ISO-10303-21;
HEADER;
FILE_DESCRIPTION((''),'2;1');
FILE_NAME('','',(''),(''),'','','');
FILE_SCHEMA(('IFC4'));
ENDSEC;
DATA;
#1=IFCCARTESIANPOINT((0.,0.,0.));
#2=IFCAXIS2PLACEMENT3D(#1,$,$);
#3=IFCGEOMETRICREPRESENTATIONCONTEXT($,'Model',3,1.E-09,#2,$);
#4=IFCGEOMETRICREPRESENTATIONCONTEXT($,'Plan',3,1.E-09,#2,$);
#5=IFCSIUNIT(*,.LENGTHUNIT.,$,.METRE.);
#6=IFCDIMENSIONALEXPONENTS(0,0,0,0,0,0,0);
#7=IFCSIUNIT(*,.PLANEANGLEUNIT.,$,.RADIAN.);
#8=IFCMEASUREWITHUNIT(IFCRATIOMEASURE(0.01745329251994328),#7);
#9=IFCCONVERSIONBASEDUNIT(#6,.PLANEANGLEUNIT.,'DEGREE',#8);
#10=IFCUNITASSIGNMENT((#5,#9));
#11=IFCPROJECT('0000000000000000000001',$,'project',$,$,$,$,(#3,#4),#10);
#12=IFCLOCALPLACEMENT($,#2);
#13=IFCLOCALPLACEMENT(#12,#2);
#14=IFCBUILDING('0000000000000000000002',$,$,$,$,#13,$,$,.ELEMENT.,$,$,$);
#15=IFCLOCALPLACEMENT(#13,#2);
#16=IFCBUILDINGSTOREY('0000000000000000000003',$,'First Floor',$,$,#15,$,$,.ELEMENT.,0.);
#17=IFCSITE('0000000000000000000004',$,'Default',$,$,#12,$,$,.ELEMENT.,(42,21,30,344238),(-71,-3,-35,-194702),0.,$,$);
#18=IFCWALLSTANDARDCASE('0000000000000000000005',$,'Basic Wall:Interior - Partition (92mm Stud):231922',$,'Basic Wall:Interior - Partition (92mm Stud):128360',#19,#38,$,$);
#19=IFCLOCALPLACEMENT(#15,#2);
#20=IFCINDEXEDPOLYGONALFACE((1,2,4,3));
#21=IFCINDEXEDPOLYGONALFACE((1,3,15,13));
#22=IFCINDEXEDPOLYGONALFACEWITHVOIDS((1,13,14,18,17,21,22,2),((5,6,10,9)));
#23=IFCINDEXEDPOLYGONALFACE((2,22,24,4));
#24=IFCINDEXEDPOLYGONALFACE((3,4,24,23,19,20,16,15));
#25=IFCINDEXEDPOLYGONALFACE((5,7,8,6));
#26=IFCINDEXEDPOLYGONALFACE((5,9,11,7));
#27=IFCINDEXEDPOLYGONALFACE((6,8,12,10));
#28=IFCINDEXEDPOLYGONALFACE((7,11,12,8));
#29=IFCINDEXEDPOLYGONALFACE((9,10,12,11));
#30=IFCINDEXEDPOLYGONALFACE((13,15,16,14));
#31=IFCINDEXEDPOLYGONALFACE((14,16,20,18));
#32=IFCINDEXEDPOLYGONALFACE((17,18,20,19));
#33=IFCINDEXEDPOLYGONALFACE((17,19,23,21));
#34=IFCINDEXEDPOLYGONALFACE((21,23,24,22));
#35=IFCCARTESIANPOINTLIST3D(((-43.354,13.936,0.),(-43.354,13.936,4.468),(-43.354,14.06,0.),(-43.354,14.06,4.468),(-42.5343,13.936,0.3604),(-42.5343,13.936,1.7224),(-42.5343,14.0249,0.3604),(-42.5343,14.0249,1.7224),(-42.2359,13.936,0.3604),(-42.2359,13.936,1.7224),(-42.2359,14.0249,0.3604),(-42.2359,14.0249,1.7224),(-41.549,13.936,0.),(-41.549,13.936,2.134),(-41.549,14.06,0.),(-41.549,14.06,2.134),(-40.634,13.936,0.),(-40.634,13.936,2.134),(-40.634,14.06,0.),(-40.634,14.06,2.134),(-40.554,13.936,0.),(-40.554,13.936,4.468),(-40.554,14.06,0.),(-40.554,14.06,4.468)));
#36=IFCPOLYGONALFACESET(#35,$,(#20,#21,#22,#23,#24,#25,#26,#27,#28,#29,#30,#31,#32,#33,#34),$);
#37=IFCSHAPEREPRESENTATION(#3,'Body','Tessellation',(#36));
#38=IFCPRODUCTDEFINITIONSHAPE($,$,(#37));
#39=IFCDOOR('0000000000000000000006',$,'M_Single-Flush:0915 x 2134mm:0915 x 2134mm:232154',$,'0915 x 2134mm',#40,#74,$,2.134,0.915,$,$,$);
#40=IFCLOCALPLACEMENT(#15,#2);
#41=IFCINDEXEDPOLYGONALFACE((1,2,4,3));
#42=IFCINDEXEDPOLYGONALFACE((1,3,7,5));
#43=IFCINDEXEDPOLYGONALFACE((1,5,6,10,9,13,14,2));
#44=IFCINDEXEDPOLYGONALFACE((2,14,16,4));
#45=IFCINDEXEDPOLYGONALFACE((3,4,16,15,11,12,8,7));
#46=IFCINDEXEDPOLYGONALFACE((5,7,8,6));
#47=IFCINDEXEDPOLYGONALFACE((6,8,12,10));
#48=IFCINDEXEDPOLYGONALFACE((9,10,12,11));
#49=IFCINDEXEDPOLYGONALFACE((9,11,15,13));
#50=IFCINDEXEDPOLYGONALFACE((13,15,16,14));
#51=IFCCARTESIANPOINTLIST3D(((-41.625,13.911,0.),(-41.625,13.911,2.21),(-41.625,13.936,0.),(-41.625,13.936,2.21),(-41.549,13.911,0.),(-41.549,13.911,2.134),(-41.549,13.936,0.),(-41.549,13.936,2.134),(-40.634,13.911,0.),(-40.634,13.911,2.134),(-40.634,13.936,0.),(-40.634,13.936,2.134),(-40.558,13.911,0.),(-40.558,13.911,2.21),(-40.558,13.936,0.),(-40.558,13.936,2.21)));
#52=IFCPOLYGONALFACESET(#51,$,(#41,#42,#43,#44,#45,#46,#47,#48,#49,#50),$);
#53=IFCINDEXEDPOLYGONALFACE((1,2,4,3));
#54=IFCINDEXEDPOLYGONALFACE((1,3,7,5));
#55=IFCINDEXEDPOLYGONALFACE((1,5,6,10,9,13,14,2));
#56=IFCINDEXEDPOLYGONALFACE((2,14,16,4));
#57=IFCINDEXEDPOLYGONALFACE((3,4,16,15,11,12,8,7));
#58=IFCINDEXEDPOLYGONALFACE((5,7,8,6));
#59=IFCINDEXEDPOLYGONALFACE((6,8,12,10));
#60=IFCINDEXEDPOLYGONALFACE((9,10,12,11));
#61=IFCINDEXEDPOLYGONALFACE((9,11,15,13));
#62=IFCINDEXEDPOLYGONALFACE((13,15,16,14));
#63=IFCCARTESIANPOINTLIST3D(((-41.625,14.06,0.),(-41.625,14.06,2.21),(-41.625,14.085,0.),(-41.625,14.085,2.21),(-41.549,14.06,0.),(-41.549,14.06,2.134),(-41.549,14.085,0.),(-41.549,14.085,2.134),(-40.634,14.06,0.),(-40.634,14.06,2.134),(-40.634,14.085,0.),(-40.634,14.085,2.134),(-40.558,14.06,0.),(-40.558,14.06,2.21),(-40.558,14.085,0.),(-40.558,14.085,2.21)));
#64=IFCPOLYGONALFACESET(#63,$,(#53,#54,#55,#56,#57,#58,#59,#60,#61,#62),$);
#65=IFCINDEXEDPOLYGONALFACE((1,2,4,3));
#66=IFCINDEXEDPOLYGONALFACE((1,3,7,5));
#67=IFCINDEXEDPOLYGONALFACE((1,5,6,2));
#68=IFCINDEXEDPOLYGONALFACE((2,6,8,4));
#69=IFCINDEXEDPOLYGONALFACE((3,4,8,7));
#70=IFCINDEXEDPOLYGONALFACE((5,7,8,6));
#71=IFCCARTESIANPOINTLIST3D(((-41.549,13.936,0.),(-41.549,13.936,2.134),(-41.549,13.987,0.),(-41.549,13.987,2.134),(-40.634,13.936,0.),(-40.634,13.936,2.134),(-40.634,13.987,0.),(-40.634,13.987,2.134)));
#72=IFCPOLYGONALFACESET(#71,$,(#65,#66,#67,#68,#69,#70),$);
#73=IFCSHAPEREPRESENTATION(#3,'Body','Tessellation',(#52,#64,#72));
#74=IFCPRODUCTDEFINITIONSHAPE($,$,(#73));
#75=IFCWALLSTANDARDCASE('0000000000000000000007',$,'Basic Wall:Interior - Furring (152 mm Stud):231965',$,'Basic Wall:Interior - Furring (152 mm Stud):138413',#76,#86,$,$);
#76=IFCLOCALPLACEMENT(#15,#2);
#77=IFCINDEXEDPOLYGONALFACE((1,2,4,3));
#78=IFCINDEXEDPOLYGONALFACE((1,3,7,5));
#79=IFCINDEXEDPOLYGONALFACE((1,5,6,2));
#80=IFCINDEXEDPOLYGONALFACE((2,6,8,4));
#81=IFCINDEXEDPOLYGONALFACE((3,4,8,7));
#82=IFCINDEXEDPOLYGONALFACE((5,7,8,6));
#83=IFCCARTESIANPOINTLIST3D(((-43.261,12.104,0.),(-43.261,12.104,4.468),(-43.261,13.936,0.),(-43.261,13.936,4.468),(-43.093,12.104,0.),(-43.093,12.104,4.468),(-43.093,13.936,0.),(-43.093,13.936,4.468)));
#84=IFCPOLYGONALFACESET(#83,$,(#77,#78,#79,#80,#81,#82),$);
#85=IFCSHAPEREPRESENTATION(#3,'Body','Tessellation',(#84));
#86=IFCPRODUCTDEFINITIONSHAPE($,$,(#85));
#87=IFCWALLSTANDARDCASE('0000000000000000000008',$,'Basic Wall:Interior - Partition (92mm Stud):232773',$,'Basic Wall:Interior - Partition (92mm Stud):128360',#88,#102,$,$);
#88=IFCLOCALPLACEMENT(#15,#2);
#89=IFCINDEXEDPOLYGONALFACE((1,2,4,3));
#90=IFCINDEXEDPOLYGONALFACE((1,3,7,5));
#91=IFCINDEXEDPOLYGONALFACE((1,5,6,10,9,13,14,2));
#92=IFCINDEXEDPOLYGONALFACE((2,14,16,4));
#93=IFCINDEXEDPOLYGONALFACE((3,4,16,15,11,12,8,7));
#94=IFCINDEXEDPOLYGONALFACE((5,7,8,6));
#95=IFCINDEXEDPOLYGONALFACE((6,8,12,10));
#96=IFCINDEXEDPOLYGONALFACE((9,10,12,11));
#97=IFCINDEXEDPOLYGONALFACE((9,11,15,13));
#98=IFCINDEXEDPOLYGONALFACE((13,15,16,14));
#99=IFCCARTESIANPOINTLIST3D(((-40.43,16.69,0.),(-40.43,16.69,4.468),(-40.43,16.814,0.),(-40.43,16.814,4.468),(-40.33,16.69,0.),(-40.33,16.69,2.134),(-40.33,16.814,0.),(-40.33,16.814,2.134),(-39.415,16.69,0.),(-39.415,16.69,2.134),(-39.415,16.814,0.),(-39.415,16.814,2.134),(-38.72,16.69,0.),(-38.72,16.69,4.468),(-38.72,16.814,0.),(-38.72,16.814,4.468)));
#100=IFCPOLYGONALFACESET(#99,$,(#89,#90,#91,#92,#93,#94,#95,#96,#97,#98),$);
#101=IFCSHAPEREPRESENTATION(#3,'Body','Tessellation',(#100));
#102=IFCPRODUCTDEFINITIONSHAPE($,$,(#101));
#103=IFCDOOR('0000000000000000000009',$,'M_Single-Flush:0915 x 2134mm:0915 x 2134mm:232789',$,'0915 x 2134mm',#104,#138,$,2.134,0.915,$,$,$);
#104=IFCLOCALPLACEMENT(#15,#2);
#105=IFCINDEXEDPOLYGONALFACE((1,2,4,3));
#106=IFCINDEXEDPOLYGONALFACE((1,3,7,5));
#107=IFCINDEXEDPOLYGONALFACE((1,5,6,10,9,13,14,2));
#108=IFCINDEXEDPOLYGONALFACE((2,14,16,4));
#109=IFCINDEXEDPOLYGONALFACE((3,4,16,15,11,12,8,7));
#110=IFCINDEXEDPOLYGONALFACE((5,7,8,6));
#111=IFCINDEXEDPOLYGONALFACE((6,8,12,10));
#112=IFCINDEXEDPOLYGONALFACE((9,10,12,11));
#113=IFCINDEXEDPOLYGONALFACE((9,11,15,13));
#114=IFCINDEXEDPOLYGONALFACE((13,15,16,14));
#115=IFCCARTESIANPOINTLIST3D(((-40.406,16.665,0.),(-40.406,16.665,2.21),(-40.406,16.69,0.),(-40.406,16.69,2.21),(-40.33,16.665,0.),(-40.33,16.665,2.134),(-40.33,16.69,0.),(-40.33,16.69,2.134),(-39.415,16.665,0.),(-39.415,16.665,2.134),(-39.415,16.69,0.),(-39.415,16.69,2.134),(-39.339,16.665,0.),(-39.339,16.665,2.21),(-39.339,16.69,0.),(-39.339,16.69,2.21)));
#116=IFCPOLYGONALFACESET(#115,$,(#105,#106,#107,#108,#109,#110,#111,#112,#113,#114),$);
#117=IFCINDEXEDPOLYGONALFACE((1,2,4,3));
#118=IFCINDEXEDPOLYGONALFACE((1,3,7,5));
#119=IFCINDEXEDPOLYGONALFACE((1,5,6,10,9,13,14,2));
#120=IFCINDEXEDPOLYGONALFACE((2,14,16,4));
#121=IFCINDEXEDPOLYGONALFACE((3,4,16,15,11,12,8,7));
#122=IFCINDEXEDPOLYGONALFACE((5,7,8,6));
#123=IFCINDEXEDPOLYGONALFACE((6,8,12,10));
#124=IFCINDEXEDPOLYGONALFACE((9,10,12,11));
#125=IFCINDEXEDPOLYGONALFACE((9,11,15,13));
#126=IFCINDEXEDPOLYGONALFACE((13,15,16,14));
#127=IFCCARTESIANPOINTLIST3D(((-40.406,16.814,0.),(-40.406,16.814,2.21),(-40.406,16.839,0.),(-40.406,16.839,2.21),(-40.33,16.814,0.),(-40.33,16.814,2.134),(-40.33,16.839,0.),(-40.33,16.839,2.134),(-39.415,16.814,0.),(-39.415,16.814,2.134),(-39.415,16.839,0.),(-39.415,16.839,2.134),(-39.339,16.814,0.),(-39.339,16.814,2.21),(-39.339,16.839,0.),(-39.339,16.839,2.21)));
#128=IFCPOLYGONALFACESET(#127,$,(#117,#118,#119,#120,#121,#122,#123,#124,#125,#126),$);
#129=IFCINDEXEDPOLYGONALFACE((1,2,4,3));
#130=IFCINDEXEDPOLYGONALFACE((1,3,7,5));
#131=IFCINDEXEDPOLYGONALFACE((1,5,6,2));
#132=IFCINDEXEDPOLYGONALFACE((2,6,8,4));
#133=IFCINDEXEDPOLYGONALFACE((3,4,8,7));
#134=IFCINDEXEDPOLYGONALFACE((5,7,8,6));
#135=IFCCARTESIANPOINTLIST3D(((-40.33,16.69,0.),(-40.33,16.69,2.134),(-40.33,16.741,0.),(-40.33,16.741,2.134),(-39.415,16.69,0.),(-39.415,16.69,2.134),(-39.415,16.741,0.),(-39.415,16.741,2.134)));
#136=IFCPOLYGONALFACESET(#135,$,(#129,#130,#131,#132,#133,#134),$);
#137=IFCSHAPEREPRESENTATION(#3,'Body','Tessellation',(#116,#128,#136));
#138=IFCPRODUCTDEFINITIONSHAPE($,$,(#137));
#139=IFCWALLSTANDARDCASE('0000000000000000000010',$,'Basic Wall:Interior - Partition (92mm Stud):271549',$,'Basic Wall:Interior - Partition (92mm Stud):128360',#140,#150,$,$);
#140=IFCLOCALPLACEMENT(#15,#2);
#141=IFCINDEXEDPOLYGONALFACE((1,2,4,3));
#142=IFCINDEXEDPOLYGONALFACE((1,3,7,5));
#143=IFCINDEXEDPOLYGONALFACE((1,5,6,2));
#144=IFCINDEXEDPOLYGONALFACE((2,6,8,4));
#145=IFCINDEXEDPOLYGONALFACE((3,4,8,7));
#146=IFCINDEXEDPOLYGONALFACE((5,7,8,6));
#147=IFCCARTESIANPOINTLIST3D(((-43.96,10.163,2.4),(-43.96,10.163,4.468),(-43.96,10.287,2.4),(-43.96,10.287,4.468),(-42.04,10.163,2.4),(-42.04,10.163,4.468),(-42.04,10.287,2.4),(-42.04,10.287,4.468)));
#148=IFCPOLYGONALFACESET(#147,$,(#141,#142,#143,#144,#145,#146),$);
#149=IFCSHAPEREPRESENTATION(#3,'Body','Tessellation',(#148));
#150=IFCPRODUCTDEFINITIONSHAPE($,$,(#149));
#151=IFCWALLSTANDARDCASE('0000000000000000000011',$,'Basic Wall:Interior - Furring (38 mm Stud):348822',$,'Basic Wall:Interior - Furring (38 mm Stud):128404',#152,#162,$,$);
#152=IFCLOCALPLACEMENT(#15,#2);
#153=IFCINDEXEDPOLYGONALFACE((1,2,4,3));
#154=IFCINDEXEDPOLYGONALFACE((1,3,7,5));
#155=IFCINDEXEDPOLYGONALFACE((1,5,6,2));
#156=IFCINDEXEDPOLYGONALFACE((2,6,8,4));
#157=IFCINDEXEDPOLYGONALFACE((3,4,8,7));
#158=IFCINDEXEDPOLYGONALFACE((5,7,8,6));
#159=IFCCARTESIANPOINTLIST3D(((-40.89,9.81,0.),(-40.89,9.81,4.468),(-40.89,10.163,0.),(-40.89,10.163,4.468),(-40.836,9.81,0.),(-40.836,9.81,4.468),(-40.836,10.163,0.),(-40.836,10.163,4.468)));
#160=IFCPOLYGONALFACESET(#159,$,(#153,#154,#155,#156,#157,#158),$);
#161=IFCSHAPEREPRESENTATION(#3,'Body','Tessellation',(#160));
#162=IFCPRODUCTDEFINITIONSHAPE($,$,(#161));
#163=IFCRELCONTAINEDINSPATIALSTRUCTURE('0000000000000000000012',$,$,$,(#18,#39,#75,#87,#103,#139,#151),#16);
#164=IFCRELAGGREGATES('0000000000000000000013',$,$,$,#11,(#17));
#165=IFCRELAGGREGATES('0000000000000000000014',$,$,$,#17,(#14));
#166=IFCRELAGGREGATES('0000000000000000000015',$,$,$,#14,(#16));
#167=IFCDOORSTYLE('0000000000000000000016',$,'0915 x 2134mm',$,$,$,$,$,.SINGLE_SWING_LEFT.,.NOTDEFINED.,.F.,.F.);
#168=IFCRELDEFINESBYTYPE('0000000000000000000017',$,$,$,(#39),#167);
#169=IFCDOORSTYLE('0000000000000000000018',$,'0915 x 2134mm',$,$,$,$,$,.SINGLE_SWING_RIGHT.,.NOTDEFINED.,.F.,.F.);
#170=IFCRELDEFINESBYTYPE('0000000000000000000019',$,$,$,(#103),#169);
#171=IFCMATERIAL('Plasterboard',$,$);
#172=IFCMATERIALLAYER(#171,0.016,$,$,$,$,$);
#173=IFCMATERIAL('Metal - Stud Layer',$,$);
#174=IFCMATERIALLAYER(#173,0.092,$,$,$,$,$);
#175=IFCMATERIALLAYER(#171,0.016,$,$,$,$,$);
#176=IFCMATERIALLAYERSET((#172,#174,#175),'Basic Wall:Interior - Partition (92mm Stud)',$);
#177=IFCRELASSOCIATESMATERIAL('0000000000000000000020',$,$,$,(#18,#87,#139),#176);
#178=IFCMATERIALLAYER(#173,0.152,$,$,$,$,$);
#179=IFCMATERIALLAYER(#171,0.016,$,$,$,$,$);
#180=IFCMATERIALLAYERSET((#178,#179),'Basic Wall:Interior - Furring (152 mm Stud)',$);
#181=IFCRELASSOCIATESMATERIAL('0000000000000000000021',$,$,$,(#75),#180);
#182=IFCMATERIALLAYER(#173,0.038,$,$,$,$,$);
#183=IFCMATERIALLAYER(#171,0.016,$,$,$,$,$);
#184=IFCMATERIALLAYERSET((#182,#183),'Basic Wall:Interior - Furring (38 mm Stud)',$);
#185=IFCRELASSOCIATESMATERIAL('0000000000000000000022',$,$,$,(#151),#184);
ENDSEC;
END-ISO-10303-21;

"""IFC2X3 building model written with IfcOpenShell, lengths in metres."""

from ifc_helpers import new_model, entity, si_unit, converted_unit, frame, frame_2d, origin, origin_2d_with_axis, place, context, project, spatial, polyline, rectangle, outline, extrude, source, transform, mapped, material, layer, layer_set, layer_usage, type_object, type_shapes, element, fill, save


model = new_model("IFC2X3")

# Units and contexts
model_context = context("Model", 3, precision=1e-09, world=origin())
plan_context = context("Plan", 3, precision=1e-09, world=origin())
ifc_project = project(units=[si_unit("LENGTHUNIT", "METRE"), converted_unit("PLANEANGLEUNIT", "DEGREE", entity("IfcRatioMeasure", 0.01745329251994328), si_unit("PLANEANGLEUNIT", "RADIAN"), dimensions=[0, 0, 0, 0, 0, 0, 0])], contexts=[model_context, plan_context])

# Site, building, storey
site_placement = place(None, origin())
site = spatial("IfcSite", under=ifc_project, at=site_placement, Name="Default", CompositionType="ELEMENT", RefLatitude=(42, 21, 30, 344238), RefLongitude=(-71, -3, -35, -194702), RefElevation=0.0)
building_placement = place(site_placement, origin())
building = spatial("IfcBuilding", under=site, at=building_placement, CompositionType="ELEMENT")
storey_placement = place(building_placement, origin())
storey = spatial("IfcBuildingStorey", under=building, at=storey_placement, Name="First Floor", CompositionType="ELEMENT", Elevation=0.0)

# Shared definitions
ifc_material_1 = material(Name="Metal - Stud Layer")
ifc_layer_1 = layer(ifc_material_1, 0.038)
ifc_material_2 = material(Name="Plasterboard")
ifc_layer_2 = layer(ifc_material_2, 0.016)
ifc_layer_set_1 = layer_set([ifc_layer_1, ifc_layer_2], Name="Basic Wall:Interior - Furring (38 mm Stud)")

# Shared definitions
ifc_layer_3 = layer(ifc_material_2, 0.016)
ifc_layer_4 = layer(ifc_material_1, 0.092)
ifc_layer_5 = layer(ifc_material_2, 0.016)
ifc_layer_set_2 = layer_set([ifc_layer_3, ifc_layer_4, ifc_layer_5], Name="Basic Wall:Interior - Partition (92mm Stud)")
door_style_1 = type_object("IfcDoorStyle", Name="0915 x 2134mm", ConstructionType="NOTDEFINED", OperationType="SINGLE_SWING_LEFT", ParameterTakesPrecedence=False, Sizeable=False)
shared_shape_1 = source(origin(), model_context, "Body", "SweptSolid", [
    extrude(outline(polyline([(-0.5335, -1.124), (0.5335, -1.124), (0.5335, 1.086), (0.4575, 1.086), (0.4575, -1.048), (-0.4575, -1.048), (-0.4575, 1.086), (-0.5335, 1.086), (-0.5335, -1.124)])), frame((0.4575, 0.149, 1.086), z_axis=(0.0, -1.0, 0.0), x_axis=(-1.0, 0.0, 0.0)), (0.0, 0.0, 1.0), 0.025),
    extrude(outline(polyline([(-1.124, -0.5335), (1.086, -0.5335), (1.086, -0.4575), (-1.048, -0.4575), (-1.048, 0.4575), (1.086, 0.4575), (1.086, 0.5335), (-1.124, 0.5335), (-1.124, -0.5335)])), frame((0.4575, 0.0, 1.086), z_axis=(0.0, -1.0, 0.0), x_axis=(0.0, 0.0, -1.0)), (0.0, 0.0, 1.0), 0.025),
    extrude(rectangle(XDim=0.915, YDim=0.051, at=origin_2d_with_axis()), frame((0.4575, 0.0985, 0.0)), (0.0, 0.0, 1.0), 2.134),
])
type_shapes(door_style_1, [shared_shape_1])

# Shared definitions
door_style_2 = type_object("IfcDoorStyle", Name="0915 x 2134mm", ConstructionType="NOTDEFINED", OperationType="SINGLE_SWING_RIGHT", ParameterTakesPrecedence=False, Sizeable=False)
shared_shape_2 = source(origin(), model_context, "Body", "SweptSolid", [
    extrude(outline(polyline([(-0.5335, -1.124), (0.5335, -1.124), (0.5335, 1.086), (0.4575, 1.086), (0.4575, -1.048), (-0.4575, -1.048), (-0.4575, 1.086), (-0.5335, 1.086), (-0.5335, -1.124)])), frame((0.4575, 0.124, 1.086), z_axis=(0.0, 1.0, 0.0), x_axis=(1.0, 0.0, 0.0)), (0.0, 0.0, 1.0), 0.025),
    extrude(outline(polyline([(-1.124, -0.5335), (1.086, -0.5335), (1.086, -0.4575), (-1.048, -0.4575), (-1.048, 0.4575), (1.086, 0.4575), (1.086, 0.5335), (-1.124, 0.5335), (-1.124, -0.5335)])), frame((0.4575, -0.025, 1.086), z_axis=(0.0, 1.0, 0.0), x_axis=(0.0, 0.0, -1.0)), (0.0, 0.0, 1.0), 0.025),
    extrude(rectangle(XDim=0.051, YDim=0.915, at=origin_2d_with_axis()), frame((0.4575, 0.0985, 0.0), z_axis=(0.0, 0.0, 1.0), x_axis=(0.0, 1.0, 0.0)), (0.0, 0.0, 1.0), 2.134),
])
type_shapes(door_style_2, [shared_shape_2])

# Wall, openings, door
ifc_layer_usage_1 = layer_usage(ifc_layer_set_2, "AXIS2", "NEGATIVE", 0.062)
wall_1_placement = place(storey_placement, frame((-43.354, 13.998, 0.0)))
wall_1 = element("IfcWallStandardCase", 1, at=wall_1_placement, inside=storey, material=ifc_layer_usage_1, Name="Basic Wall:Interior - Partition (92mm Stud):231922", ObjectType="Basic Wall:Interior - Partition (92mm Stud):128360", context=model_context, shape_type="SweptSolid", body=[
    extrude(rectangle(XDim=2.8, YDim=0.124, at=frame_2d((1.4, 0.0), x_axis=(-1.0, 0.0))), origin(), (0.0, 0.0, 1.0), 4.468),
])
opening_1_placement = place(wall_1_placement, origin())
element("IfcOpeningElement", 2, at=opening_1_placement, cuts=wall_1, ObjectType="Opening", context=model_context, shape_type="SweptSolid", body=[
    extrude(rectangle(XDim=1.3621, YDim=0.2984, at=origin_2d_with_axis()), frame((0.9689, -0.1255, 1.0414), z_axis=(0.0, 1.0, 0.0), x_axis=(0.0, 0.0, -1.0)), (0.0, 0.0, 1.0), 0.1524),
])
opening_2_placement = place(wall_1_placement, frame((2.72, 0.062, 0.0)))
opening_2 = element("IfcOpeningElement", 3, at=opening_2_placement, cuts=wall_1, ObjectType="Opening", context=model_context, shape_type="SweptSolid", body=[
    extrude(rectangle(XDim=0.915, YDim=2.134, at=frame_2d((1.067, 0.4575), x_axis=(0.0, -1.0))), frame((0.0, 0.0, 0.0), z_axis=(0.0, -1.0, 0.0), x_axis=(0.0, 0.0, 1.0)), (0.0, 0.0, 1.0), 0.124),
])
door_1_placement = place(opening_2_placement, frame((0.0, 0.0, 0.0), z_axis=(0.0, 0.0, 1.0), x_axis=(-1.0, 0.0, 0.0)))
door_1 = element("IfcDoor", 4, at=door_1_placement, inside=storey, type_object=door_style_1, Name="M_Single-Flush:0915 x 2134mm:0915 x 2134mm:232154", ObjectType="0915 x 2134mm", OverallHeight=2.134, OverallWidth=0.915, context=model_context, shape_type="MappedRepresentation", body=[
    mapped(shared_shape_1, transform((0.0, 0.0, 0.0), scale=1.0)),
])
fill(opening_2, door_1)

# Wall
ifc_layer_6 = layer(ifc_material_1, 0.152)
ifc_layer_7 = layer(ifc_material_2, 0.016)
ifc_layer_set_3 = layer_set([ifc_layer_6, ifc_layer_7], Name="Basic Wall:Interior - Furring (152 mm Stud)")
ifc_layer_usage_2 = layer_usage(ifc_layer_set_3, "AXIS2", "POSITIVE", -0.084)
wall_2_placement = place(storey_placement, frame((-43.177, 13.936, 0.0), z_axis=(0.0, 0.0, 1.0), x_axis=(0.0, -1.0, 0.0)))
element("IfcWallStandardCase", 5, at=wall_2_placement, inside=storey, material=ifc_layer_usage_2, Name="Basic Wall:Interior - Furring (152 mm Stud):231965", ObjectType="Basic Wall:Interior - Furring (152 mm Stud):138413", context=model_context, shape_type="SweptSolid", body=[
    extrude(rectangle(XDim=1.832, YDim=0.168, at=frame_2d((0.916, 0.0), x_axis=(-1.0, 0.0))), origin(), (0.0, 0.0, 1.0), 4.468),
])

# Wall, opening, door
ifc_layer_usage_3 = layer_usage(ifc_layer_set_2, "AXIS2", "NEGATIVE", 0.062)
wall_3_placement = place(storey_placement, frame((-38.72, 16.752, 0.0), z_axis=(0.0, 0.0, 1.0), x_axis=(-1.0, 0.0, 0.0)))
wall_3 = element("IfcWallStandardCase", 6, at=wall_3_placement, inside=storey, material=ifc_layer_usage_3, Name="Basic Wall:Interior - Partition (92mm Stud):232773", ObjectType="Basic Wall:Interior - Partition (92mm Stud):128360", context=model_context, shape_type="SweptSolid", body=[
    extrude(rectangle(XDim=1.71, YDim=0.124, at=frame_2d((0.855, 0.0), x_axis=(-1.0, 0.0))), origin(), (0.0, 0.0, 1.0), 4.468),
])
opening_3_placement = place(wall_3_placement, frame((0.695, -0.062, 0.0)))
opening_3 = element("IfcOpeningElement", 7, at=opening_3_placement, cuts=wall_3, ObjectType="Opening", context=model_context, shape_type="SweptSolid", body=[
    extrude(rectangle(XDim=0.915, YDim=2.134, at=frame_2d((1.067, 0.4575), x_axis=(0.0, 1.0))), frame((0.0, 0.0, 0.0), z_axis=(0.0, 1.0, 0.0), x_axis=(0.0, 0.0, 1.0)), (0.0, 0.0, 1.0), 0.124),
])
door_2_placement = place(opening_3_placement, origin())
door_2 = element("IfcDoor", 8, at=door_2_placement, inside=storey, type_object=door_style_2, Name="M_Single-Flush:0915 x 2134mm:0915 x 2134mm:232789", ObjectType="0915 x 2134mm", OverallHeight=2.134, OverallWidth=0.915, context=model_context, shape_type="MappedRepresentation", body=[
    mapped(shared_shape_2, transform((0.0, 0.0, 0.0), scale=1.0)),
])
fill(opening_3, door_2)

# Walls
ifc_layer_usage_4 = layer_usage(ifc_layer_set_2, "AXIS2", "NEGATIVE", 0.062)
wall_4_placement = place(storey_placement, frame((-43.96, 10.225, 2.4)))
element("IfcWallStandardCase", 9, at=wall_4_placement, inside=storey, material=ifc_layer_usage_4, Name="Basic Wall:Interior - Partition (92mm Stud):271549", ObjectType="Basic Wall:Interior - Partition (92mm Stud):128360", context=model_context, shape_type="SweptSolid", body=[
    extrude(rectangle(XDim=1.92, YDim=0.124, at=frame_2d((0.96, 0.0), x_axis=(-1.0, 0.0))), origin(), (0.0, 0.0, 1.0), 2.068),
])
ifc_layer_usage_5 = layer_usage(ifc_layer_set_1, "AXIS2", "NEGATIVE", 0.027)
wall_5_placement = place(storey_placement, frame((-40.863, 10.163, 0.0), z_axis=(0.0, 0.0, 1.0), x_axis=(0.0, -1.0, 0.0)))
element("IfcWallStandardCase", 10, at=wall_5_placement, inside=storey, material=ifc_layer_usage_5, Name="Basic Wall:Interior - Furring (38 mm Stud):348822", ObjectType="Basic Wall:Interior - Furring (38 mm Stud):128404", context=model_context, shape_type="SweptSolid", body=[
    extrude(rectangle(XDim=0.353, YDim=0.054, at=frame_2d((0.1765, 0.0), x_axis=(-1.0, 0.0))), origin(), (0.0, 0.0, 1.0), 4.468),
])

save(model, "model.ifc")
